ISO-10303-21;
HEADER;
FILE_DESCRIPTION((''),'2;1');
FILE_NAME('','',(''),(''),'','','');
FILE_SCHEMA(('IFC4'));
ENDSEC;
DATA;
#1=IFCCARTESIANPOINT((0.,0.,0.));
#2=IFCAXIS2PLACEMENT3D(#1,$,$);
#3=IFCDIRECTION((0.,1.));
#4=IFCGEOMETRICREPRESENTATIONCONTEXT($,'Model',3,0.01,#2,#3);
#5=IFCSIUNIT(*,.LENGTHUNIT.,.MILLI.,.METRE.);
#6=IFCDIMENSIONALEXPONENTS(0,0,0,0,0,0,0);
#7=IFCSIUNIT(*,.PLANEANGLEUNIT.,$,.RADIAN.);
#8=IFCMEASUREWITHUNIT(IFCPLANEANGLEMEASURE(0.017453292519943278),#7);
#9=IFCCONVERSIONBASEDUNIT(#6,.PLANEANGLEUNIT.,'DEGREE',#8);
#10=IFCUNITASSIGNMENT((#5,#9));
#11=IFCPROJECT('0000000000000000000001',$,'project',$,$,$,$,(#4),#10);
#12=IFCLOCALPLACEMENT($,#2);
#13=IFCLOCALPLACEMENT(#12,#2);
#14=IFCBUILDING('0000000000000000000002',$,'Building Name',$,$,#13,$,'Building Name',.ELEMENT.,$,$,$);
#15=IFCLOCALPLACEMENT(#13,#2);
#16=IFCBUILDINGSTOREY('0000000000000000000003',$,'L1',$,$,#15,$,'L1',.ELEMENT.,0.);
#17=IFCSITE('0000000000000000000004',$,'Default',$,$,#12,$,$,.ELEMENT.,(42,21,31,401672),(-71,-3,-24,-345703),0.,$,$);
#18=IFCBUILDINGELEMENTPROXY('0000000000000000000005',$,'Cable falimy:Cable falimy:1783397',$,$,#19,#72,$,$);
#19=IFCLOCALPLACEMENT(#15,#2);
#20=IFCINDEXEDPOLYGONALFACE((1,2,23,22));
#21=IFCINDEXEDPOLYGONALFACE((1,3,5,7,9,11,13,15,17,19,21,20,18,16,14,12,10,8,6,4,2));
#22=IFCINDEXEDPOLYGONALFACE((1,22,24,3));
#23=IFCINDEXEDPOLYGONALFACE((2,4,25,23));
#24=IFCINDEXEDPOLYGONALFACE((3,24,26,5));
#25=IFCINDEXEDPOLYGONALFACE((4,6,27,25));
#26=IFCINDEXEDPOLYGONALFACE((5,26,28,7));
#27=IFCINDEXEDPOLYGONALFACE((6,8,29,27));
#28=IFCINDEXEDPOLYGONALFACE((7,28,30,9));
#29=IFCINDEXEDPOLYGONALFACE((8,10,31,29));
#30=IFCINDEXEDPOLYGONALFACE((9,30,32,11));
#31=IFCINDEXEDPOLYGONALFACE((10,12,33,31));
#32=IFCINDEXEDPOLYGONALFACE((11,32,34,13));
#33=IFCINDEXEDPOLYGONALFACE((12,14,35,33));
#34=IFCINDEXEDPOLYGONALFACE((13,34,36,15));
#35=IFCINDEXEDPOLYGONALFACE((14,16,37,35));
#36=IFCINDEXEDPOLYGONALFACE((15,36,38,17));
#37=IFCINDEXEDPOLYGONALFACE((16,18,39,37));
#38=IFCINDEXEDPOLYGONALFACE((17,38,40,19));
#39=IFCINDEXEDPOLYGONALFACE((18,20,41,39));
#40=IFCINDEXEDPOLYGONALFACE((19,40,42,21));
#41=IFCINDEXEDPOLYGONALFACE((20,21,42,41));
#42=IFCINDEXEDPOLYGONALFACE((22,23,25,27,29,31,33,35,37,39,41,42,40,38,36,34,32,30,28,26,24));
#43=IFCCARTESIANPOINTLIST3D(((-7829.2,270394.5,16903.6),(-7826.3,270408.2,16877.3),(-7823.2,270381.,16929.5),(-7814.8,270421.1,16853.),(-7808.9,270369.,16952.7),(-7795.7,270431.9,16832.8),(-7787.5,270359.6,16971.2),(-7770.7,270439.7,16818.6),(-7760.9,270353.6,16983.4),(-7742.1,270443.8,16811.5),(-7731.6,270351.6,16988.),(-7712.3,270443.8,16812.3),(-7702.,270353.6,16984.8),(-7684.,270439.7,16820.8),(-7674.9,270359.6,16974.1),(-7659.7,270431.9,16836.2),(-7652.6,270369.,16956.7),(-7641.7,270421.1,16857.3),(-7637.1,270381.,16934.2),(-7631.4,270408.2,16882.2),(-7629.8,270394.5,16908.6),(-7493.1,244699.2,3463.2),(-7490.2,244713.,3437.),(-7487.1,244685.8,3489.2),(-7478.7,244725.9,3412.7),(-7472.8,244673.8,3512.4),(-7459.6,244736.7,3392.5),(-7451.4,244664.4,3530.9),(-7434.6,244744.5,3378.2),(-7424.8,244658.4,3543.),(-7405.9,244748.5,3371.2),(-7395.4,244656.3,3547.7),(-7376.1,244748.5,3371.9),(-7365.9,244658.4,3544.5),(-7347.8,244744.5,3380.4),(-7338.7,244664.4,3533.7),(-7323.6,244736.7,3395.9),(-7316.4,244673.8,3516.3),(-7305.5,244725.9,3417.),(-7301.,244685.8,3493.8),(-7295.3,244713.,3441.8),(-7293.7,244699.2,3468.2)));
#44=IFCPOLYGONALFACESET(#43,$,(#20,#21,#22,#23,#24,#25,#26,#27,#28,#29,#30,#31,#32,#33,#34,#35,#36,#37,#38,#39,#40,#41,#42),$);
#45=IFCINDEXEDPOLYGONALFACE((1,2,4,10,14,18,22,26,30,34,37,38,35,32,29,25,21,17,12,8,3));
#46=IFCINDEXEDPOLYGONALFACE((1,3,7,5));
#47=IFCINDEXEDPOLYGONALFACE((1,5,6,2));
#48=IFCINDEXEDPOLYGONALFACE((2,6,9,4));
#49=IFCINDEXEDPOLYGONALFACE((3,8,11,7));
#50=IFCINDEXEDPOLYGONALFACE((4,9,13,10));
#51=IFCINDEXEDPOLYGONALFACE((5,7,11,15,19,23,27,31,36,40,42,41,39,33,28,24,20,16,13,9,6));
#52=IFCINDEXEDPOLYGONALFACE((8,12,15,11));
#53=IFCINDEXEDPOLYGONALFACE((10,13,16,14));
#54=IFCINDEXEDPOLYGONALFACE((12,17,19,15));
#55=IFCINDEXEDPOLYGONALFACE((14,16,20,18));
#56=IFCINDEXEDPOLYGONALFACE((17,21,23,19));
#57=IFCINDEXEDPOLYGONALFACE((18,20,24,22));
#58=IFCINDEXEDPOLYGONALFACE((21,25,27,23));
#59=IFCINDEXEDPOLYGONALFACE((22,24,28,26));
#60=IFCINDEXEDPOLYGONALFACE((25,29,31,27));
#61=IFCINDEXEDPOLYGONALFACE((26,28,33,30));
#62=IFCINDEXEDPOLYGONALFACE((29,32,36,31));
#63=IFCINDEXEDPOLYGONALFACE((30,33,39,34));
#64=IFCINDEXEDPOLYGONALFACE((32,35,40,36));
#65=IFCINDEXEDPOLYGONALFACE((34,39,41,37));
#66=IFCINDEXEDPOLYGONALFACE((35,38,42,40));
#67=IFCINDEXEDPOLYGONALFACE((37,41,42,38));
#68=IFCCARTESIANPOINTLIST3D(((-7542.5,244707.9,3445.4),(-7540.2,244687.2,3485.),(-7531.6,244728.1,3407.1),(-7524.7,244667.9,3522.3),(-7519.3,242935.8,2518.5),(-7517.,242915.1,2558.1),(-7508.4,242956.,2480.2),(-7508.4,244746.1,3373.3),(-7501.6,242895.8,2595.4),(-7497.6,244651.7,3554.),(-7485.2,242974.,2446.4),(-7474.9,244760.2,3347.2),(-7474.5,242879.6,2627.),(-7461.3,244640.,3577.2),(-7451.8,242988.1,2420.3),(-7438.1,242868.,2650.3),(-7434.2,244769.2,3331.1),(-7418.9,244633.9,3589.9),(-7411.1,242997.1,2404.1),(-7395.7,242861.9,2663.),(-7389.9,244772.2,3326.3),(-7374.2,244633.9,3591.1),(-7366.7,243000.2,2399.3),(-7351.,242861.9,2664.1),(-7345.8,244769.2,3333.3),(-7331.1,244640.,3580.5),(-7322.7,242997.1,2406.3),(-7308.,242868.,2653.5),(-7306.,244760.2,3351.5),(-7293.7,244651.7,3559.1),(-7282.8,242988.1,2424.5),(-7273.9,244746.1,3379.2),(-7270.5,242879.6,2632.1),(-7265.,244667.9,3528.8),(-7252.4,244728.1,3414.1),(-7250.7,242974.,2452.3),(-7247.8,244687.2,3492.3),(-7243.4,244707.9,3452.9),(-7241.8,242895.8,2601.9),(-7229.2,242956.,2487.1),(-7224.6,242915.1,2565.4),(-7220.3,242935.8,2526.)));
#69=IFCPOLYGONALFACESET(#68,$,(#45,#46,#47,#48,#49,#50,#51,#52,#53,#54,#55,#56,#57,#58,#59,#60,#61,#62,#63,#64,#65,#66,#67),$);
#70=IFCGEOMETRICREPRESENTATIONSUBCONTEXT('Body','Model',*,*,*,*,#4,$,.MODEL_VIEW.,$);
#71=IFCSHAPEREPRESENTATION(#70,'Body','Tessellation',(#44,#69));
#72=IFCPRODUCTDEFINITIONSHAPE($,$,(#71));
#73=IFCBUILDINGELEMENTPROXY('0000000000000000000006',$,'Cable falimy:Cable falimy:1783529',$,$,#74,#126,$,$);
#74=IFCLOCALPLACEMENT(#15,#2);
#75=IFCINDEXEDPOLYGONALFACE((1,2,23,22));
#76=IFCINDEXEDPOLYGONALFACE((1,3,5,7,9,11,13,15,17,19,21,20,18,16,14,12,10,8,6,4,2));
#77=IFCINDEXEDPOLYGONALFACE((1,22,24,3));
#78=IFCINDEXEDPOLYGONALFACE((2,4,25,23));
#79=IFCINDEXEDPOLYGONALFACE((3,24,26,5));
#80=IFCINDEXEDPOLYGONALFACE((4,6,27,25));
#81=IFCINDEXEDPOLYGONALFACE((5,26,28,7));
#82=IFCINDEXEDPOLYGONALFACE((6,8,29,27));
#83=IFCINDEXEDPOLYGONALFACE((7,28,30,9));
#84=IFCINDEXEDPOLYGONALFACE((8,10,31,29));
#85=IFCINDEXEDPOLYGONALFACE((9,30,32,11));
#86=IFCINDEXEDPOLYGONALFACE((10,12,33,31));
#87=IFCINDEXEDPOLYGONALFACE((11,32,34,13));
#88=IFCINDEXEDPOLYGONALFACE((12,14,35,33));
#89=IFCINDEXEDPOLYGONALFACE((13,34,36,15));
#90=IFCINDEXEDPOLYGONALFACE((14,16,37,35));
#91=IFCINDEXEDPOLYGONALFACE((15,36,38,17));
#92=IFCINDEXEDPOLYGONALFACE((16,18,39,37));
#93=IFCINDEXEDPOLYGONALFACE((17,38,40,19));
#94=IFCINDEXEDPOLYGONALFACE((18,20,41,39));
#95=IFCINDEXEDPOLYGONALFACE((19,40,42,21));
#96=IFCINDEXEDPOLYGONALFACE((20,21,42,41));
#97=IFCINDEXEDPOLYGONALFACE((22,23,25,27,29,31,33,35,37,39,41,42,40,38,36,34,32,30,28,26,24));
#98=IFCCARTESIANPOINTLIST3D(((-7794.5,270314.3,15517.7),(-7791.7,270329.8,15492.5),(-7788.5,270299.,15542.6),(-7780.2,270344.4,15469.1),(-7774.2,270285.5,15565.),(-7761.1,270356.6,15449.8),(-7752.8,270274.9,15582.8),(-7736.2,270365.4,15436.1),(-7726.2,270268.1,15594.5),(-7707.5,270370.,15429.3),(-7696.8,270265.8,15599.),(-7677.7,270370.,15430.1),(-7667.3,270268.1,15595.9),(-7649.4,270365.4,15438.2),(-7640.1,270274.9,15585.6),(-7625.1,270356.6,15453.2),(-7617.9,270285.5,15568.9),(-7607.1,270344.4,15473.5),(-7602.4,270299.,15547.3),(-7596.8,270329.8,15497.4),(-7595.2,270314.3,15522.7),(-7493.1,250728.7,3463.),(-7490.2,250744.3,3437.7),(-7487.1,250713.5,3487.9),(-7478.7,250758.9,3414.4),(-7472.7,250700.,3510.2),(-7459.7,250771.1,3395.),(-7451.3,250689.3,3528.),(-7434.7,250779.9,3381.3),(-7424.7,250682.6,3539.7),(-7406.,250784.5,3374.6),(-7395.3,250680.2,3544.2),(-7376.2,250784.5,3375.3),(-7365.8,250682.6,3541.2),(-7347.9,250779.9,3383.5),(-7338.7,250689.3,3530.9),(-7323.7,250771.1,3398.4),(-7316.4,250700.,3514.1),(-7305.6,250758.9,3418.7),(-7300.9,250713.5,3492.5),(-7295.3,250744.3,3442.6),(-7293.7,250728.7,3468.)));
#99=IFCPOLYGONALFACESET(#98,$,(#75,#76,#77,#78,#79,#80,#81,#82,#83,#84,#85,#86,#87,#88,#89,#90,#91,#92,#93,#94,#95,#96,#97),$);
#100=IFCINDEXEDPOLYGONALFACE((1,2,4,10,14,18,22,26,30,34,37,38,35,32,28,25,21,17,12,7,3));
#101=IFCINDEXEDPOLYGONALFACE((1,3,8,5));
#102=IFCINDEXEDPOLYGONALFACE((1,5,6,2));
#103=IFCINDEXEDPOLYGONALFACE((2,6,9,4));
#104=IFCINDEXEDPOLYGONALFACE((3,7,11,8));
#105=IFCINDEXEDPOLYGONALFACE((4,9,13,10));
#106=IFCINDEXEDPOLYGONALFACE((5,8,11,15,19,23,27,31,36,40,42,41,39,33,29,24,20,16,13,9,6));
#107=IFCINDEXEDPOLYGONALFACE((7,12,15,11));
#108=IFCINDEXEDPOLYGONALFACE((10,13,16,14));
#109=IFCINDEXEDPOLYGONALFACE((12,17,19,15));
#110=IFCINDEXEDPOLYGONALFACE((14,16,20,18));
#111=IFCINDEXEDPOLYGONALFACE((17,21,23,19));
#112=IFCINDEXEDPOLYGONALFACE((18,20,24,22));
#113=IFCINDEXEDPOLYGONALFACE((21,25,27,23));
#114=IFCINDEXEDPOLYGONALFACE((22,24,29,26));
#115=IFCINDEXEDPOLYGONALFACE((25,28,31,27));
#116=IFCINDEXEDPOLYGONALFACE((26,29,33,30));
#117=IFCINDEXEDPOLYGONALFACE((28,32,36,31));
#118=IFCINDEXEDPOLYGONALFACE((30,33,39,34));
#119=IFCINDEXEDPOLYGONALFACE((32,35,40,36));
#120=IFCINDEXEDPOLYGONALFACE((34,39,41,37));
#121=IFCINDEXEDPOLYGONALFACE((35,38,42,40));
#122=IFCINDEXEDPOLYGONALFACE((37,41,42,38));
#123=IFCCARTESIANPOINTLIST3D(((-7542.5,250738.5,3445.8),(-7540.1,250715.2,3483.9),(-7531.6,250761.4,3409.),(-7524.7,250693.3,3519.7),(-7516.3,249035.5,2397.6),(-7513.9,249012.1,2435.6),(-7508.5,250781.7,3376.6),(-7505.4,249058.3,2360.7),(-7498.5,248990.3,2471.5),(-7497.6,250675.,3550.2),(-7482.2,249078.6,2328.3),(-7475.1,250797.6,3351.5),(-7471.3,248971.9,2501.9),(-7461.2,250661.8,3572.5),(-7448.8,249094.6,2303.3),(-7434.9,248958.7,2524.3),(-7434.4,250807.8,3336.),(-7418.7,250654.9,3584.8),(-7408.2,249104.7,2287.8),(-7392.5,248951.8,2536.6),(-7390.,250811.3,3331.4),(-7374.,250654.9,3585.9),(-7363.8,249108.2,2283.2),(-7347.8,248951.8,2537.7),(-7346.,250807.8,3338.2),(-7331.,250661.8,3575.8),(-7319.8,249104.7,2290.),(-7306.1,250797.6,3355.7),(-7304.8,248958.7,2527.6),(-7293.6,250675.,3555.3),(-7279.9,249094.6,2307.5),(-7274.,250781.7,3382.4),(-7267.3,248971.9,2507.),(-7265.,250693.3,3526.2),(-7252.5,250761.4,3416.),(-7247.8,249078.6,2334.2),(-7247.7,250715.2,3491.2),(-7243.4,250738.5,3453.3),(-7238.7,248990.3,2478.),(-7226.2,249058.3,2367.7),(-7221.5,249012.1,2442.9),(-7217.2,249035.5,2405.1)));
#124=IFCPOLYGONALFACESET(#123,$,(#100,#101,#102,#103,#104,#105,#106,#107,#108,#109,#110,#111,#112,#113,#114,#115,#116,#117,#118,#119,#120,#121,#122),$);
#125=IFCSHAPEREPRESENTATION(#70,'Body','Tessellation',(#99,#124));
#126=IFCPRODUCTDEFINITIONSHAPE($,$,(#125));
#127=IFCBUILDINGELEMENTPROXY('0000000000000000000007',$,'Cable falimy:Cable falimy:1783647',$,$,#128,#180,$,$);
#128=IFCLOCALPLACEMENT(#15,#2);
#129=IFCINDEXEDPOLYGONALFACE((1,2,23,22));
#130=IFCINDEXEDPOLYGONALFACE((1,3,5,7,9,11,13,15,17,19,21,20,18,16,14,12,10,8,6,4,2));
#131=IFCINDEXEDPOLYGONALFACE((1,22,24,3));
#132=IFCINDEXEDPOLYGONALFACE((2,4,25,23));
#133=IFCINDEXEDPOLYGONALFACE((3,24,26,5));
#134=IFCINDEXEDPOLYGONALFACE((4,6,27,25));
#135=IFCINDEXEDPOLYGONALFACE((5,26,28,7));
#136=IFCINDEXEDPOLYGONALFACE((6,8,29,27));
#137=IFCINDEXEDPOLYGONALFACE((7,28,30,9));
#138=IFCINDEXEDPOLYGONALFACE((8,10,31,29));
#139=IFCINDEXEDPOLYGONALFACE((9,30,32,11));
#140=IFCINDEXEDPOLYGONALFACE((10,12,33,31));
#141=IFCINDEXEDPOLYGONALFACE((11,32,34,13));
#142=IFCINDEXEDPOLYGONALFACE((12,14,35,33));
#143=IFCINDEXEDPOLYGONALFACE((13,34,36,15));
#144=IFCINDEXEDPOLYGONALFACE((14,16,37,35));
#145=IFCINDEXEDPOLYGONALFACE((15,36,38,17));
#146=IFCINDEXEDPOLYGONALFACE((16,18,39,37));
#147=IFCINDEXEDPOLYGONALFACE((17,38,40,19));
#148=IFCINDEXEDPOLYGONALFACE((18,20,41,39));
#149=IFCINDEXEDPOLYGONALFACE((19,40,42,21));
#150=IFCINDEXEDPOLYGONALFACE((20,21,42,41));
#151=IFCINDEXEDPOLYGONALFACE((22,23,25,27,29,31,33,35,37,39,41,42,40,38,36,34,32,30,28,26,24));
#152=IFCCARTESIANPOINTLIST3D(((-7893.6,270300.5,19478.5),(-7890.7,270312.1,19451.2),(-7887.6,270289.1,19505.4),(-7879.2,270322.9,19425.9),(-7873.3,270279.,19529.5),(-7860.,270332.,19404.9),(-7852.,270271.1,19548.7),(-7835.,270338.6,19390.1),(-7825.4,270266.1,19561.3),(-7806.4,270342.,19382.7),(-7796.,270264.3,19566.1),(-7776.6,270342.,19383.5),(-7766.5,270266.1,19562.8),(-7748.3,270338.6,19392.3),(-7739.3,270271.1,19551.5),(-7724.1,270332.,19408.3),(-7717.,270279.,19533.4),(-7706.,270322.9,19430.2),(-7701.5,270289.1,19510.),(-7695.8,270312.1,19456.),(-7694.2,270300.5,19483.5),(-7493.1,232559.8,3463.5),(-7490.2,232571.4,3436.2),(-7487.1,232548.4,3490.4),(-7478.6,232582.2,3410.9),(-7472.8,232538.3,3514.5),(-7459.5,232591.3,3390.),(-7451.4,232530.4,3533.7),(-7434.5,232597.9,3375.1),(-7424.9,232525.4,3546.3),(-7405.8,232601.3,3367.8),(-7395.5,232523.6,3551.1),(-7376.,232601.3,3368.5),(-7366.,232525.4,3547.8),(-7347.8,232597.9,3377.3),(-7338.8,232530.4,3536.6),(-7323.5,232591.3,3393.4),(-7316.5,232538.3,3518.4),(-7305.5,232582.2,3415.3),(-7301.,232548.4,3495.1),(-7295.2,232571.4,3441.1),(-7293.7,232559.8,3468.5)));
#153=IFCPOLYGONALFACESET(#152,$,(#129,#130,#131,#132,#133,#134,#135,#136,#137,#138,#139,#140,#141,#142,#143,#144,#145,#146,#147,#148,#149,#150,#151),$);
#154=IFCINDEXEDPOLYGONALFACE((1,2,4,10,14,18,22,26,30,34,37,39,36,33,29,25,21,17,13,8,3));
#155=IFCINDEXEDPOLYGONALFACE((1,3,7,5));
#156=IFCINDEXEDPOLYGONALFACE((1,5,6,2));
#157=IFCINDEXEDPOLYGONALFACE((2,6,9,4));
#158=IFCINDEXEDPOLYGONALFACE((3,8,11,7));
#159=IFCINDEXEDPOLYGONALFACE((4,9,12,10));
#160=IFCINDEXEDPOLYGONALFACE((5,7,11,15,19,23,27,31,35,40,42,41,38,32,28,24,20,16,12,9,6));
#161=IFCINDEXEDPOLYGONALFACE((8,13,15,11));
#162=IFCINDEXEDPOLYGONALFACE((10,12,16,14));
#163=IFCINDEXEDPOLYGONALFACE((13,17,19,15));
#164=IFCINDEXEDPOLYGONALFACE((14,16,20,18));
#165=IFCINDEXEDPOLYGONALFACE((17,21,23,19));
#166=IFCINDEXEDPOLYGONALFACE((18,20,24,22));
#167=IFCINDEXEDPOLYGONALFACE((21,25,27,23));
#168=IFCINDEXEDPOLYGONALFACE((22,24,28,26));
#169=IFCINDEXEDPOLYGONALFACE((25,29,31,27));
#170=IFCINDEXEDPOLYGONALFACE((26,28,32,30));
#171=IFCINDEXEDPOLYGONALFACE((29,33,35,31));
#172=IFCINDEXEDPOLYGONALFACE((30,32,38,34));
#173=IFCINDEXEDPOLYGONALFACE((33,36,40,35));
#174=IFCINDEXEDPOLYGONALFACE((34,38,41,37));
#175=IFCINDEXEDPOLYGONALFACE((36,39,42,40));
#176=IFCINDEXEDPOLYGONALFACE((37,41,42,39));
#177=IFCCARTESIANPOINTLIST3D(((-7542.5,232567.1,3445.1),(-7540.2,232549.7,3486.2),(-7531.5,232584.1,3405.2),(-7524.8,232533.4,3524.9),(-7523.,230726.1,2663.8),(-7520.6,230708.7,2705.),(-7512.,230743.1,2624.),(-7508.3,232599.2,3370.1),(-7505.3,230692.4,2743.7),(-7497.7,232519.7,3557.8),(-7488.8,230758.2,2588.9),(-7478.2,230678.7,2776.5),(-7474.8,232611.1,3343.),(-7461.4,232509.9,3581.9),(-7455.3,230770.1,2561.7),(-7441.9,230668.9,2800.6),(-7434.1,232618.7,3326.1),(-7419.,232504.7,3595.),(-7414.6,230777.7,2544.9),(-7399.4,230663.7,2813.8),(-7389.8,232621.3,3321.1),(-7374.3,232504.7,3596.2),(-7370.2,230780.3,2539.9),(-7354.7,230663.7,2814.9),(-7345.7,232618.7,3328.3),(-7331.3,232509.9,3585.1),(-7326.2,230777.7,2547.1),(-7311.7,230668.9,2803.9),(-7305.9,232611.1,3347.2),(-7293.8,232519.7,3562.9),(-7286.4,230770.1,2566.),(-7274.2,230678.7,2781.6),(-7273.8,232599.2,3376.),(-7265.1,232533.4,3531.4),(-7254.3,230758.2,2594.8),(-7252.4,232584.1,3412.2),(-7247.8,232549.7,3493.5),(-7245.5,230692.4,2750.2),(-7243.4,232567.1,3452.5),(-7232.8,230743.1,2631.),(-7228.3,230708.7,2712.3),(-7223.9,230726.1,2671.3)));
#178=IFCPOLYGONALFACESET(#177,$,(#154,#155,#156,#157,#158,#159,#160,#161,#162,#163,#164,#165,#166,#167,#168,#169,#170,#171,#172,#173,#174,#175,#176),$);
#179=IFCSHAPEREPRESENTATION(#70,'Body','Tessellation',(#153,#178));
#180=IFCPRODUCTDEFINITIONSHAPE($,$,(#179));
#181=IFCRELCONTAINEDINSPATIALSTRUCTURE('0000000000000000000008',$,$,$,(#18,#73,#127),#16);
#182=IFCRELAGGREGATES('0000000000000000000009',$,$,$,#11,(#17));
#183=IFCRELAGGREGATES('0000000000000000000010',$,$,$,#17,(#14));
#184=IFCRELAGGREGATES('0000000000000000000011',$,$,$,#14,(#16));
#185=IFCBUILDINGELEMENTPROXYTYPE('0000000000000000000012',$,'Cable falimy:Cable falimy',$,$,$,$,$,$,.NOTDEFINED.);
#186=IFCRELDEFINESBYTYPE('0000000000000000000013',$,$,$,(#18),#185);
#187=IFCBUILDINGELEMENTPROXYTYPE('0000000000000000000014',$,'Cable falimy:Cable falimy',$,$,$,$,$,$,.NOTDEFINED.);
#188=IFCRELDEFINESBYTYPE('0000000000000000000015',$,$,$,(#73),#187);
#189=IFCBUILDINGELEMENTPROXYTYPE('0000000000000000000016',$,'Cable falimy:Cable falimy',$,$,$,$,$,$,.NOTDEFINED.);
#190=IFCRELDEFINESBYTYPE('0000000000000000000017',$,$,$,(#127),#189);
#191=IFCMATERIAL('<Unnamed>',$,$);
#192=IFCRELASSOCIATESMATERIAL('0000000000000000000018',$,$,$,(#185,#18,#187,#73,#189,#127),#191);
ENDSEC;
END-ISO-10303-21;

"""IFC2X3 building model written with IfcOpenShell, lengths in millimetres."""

from ifc_helpers import new_model, entity, si_unit, converted_unit, direction, frame, frame_2d, origin, place, context, subcontext, project, spatial, circle, extrude, source, transform, mapped, material, type_object, type_shapes, element, save


model = new_model("IFC2X3")

# Units and contexts
model_context = context("Model", 3, precision=0.01, world=origin(), true_north=direction((0.0, 1.0)))
body_context = subcontext(model_context, "Body", "Model", "MODEL_VIEW")
ifc_project = project(units=[si_unit("LENGTHUNIT", "METRE", prefix="MILLI"), converted_unit("PLANEANGLEUNIT", "DEGREE", entity("IfcPlaneAngleMeasure", 0.017453292519943278), si_unit("PLANEANGLEUNIT", "RADIAN"), dimensions=[0, 0, 0, 0, 0, 0, 0])], contexts=[model_context])

# Site, building, storey
site_placement = place(None, origin())
site = spatial("IfcSite", under=ifc_project, at=site_placement, Name="Default", CompositionType="ELEMENT", RefLatitude=(42, 21, 31, 401672), RefLongitude=(-71, -3, -24, -345703), RefElevation=0.0)
building_placement = place(site_placement, origin())
building = spatial("IfcBuilding", under=site, at=building_placement, Name="Building Name", LongName="Building Name", CompositionType="ELEMENT")
storey_placement = place(building_placement, origin())
storey = spatial("IfcBuildingStorey", under=building, at=storey_placement, Name="L1", LongName="L1", CompositionType="ELEMENT", Elevation=0.0)

# Shared definitions
ifc_material = material(Name="<Unnamed>")

# Building element proxies
building_element_proxy_type_1 = type_object("IfcBuildingElementProxyType", Name="Cable falimy:Cable falimy", PredefinedType="NOTDEFINED", material=ifc_material)
shared_shape_1 = source(origin(), body_context, "Body", "SweptSolid", [
    extrude(circle(Radius=100.0, at=frame_2d((0.0, 0.0), x_axis=(1.0, 0.0))), frame((0.0, 0.0, 0.0), z_axis=(0.886042, 0.0, 0.463605), x_axis=(-0.463605, 0.0, 0.886042)), (0.0, 0.0, 1.0), 29000.0),
    extrude(circle(Radius=150.0, at=frame_2d((0.0, 0.0), x_axis=(1.0, 0.0))), frame((-1772.1, 0.0, -927.2), z_axis=(0.886042, 0.0, 0.463605), x_axis=(0.463605, 0.0, -0.886042)), (0.0, 0.0, 1.0), 2000.0),
])
type_shapes(building_element_proxy_type_1, [shared_shape_1])
proxy_1_placement = place(storey_placement, frame((-7393.2, 244702.7, 3459.1), z_axis=(-0.025001, 0.0, 0.999687), x_axis=(0.0, 1.0, 0.0)))
element("IfcBuildingElementProxy", 1, at=proxy_1_placement, inside=storey, type_object=building_element_proxy_type_1, material=ifc_material, Name="Cable falimy:Cable falimy:1783397", context=body_context, shape_type="MappedRepresentation", body=[
    mapped(shared_shape_1, transform((0.0, 0.0, 0.0), scale=1.0)),
])
building_element_proxy_type_2 = type_object("IfcBuildingElementProxyType", Name="Cable falimy:Cable falimy", PredefinedType="NOTDEFINED", material=ifc_material)
shared_shape_2 = source(origin(), body_context, "Body", "SweptSolid", [
    extrude(circle(Radius=100.0, at=frame_2d((0.0, 0.0), x_axis=(1.0, 0.0))), frame((0.0, 0.0, 0.0), z_axis=(0.851544, 0.0, 0.524283), x_axis=(-0.524283, 0.0, 0.851544)), (0.0, 0.0, 1.0), 23000.0),
    extrude(circle(Radius=150.0, at=frame_2d((0.0, 0.0), x_axis=(1.0, 0.0))), frame((-1703.1, 0.0, -1048.6), z_axis=(0.851544, 0.0, 0.524283), x_axis=(0.524283, 0.0, -0.851544)), (0.0, 0.0, 1.0), 2000.0),
])
type_shapes(building_element_proxy_type_2, [shared_shape_2])
proxy_2_placement = place(storey_placement, frame((-7393.2, 250732.7, 3459.1), z_axis=(-0.025001, 0.0, 0.999687), x_axis=(0.0, 1.0, 0.0)))
element("IfcBuildingElementProxy", 2, at=proxy_2_placement, inside=storey, type_object=building_element_proxy_type_2, material=ifc_material, Name="Cable falimy:Cable falimy:1783529", context=body_context, shape_type="MappedRepresentation", body=[
    mapped(shared_shape_2, transform((0.0, 0.0, 0.0), scale=1.0)),
])
building_element_proxy_type_3 = type_object("IfcBuildingElementProxyType", Name="Cable falimy:Cable falimy", PredefinedType="NOTDEFINED", material=ifc_material)
shared_shape_3 = source(origin(), body_context, "Body", "SweptSolid", [
    extrude(circle(Radius=100.0, at=frame_2d((0.0, 0.0), x_axis=(1.0, 0.0))), frame((0.0, 0.0, 0.0), z_axis=(0.920505, 0.0, 0.390731), x_axis=(-0.390731, 0.0, 0.920505)), (0.0, 0.0, 1.0), 41000.0),
    extrude(circle(Radius=150.0, at=frame_2d((0.0, 0.0), x_axis=(1.0, 0.0))), frame((-1841.0, 0.0, -781.5), z_axis=(0.920505, 0.0, 0.390731), x_axis=(0.390731, 0.0, -0.920505)), (0.0, 0.0, 1.0), 2000.0),
])
type_shapes(building_element_proxy_type_3, [shared_shape_3])
proxy_3_placement = place(storey_placement, frame((-7393.2, 232562.7, 3459.1), z_axis=(-0.025001, 0.0, 0.999687), x_axis=(0.0, 1.0, 0.0)))
element("IfcBuildingElementProxy", 3, at=proxy_3_placement, inside=storey, type_object=building_element_proxy_type_3, material=ifc_material, Name="Cable falimy:Cable falimy:1783647", context=body_context, shape_type="MappedRepresentation", body=[
    mapped(shared_shape_3, transform((0.0, 0.0, 0.0), scale=1.0)),
])

save(model, "model.ifc")
